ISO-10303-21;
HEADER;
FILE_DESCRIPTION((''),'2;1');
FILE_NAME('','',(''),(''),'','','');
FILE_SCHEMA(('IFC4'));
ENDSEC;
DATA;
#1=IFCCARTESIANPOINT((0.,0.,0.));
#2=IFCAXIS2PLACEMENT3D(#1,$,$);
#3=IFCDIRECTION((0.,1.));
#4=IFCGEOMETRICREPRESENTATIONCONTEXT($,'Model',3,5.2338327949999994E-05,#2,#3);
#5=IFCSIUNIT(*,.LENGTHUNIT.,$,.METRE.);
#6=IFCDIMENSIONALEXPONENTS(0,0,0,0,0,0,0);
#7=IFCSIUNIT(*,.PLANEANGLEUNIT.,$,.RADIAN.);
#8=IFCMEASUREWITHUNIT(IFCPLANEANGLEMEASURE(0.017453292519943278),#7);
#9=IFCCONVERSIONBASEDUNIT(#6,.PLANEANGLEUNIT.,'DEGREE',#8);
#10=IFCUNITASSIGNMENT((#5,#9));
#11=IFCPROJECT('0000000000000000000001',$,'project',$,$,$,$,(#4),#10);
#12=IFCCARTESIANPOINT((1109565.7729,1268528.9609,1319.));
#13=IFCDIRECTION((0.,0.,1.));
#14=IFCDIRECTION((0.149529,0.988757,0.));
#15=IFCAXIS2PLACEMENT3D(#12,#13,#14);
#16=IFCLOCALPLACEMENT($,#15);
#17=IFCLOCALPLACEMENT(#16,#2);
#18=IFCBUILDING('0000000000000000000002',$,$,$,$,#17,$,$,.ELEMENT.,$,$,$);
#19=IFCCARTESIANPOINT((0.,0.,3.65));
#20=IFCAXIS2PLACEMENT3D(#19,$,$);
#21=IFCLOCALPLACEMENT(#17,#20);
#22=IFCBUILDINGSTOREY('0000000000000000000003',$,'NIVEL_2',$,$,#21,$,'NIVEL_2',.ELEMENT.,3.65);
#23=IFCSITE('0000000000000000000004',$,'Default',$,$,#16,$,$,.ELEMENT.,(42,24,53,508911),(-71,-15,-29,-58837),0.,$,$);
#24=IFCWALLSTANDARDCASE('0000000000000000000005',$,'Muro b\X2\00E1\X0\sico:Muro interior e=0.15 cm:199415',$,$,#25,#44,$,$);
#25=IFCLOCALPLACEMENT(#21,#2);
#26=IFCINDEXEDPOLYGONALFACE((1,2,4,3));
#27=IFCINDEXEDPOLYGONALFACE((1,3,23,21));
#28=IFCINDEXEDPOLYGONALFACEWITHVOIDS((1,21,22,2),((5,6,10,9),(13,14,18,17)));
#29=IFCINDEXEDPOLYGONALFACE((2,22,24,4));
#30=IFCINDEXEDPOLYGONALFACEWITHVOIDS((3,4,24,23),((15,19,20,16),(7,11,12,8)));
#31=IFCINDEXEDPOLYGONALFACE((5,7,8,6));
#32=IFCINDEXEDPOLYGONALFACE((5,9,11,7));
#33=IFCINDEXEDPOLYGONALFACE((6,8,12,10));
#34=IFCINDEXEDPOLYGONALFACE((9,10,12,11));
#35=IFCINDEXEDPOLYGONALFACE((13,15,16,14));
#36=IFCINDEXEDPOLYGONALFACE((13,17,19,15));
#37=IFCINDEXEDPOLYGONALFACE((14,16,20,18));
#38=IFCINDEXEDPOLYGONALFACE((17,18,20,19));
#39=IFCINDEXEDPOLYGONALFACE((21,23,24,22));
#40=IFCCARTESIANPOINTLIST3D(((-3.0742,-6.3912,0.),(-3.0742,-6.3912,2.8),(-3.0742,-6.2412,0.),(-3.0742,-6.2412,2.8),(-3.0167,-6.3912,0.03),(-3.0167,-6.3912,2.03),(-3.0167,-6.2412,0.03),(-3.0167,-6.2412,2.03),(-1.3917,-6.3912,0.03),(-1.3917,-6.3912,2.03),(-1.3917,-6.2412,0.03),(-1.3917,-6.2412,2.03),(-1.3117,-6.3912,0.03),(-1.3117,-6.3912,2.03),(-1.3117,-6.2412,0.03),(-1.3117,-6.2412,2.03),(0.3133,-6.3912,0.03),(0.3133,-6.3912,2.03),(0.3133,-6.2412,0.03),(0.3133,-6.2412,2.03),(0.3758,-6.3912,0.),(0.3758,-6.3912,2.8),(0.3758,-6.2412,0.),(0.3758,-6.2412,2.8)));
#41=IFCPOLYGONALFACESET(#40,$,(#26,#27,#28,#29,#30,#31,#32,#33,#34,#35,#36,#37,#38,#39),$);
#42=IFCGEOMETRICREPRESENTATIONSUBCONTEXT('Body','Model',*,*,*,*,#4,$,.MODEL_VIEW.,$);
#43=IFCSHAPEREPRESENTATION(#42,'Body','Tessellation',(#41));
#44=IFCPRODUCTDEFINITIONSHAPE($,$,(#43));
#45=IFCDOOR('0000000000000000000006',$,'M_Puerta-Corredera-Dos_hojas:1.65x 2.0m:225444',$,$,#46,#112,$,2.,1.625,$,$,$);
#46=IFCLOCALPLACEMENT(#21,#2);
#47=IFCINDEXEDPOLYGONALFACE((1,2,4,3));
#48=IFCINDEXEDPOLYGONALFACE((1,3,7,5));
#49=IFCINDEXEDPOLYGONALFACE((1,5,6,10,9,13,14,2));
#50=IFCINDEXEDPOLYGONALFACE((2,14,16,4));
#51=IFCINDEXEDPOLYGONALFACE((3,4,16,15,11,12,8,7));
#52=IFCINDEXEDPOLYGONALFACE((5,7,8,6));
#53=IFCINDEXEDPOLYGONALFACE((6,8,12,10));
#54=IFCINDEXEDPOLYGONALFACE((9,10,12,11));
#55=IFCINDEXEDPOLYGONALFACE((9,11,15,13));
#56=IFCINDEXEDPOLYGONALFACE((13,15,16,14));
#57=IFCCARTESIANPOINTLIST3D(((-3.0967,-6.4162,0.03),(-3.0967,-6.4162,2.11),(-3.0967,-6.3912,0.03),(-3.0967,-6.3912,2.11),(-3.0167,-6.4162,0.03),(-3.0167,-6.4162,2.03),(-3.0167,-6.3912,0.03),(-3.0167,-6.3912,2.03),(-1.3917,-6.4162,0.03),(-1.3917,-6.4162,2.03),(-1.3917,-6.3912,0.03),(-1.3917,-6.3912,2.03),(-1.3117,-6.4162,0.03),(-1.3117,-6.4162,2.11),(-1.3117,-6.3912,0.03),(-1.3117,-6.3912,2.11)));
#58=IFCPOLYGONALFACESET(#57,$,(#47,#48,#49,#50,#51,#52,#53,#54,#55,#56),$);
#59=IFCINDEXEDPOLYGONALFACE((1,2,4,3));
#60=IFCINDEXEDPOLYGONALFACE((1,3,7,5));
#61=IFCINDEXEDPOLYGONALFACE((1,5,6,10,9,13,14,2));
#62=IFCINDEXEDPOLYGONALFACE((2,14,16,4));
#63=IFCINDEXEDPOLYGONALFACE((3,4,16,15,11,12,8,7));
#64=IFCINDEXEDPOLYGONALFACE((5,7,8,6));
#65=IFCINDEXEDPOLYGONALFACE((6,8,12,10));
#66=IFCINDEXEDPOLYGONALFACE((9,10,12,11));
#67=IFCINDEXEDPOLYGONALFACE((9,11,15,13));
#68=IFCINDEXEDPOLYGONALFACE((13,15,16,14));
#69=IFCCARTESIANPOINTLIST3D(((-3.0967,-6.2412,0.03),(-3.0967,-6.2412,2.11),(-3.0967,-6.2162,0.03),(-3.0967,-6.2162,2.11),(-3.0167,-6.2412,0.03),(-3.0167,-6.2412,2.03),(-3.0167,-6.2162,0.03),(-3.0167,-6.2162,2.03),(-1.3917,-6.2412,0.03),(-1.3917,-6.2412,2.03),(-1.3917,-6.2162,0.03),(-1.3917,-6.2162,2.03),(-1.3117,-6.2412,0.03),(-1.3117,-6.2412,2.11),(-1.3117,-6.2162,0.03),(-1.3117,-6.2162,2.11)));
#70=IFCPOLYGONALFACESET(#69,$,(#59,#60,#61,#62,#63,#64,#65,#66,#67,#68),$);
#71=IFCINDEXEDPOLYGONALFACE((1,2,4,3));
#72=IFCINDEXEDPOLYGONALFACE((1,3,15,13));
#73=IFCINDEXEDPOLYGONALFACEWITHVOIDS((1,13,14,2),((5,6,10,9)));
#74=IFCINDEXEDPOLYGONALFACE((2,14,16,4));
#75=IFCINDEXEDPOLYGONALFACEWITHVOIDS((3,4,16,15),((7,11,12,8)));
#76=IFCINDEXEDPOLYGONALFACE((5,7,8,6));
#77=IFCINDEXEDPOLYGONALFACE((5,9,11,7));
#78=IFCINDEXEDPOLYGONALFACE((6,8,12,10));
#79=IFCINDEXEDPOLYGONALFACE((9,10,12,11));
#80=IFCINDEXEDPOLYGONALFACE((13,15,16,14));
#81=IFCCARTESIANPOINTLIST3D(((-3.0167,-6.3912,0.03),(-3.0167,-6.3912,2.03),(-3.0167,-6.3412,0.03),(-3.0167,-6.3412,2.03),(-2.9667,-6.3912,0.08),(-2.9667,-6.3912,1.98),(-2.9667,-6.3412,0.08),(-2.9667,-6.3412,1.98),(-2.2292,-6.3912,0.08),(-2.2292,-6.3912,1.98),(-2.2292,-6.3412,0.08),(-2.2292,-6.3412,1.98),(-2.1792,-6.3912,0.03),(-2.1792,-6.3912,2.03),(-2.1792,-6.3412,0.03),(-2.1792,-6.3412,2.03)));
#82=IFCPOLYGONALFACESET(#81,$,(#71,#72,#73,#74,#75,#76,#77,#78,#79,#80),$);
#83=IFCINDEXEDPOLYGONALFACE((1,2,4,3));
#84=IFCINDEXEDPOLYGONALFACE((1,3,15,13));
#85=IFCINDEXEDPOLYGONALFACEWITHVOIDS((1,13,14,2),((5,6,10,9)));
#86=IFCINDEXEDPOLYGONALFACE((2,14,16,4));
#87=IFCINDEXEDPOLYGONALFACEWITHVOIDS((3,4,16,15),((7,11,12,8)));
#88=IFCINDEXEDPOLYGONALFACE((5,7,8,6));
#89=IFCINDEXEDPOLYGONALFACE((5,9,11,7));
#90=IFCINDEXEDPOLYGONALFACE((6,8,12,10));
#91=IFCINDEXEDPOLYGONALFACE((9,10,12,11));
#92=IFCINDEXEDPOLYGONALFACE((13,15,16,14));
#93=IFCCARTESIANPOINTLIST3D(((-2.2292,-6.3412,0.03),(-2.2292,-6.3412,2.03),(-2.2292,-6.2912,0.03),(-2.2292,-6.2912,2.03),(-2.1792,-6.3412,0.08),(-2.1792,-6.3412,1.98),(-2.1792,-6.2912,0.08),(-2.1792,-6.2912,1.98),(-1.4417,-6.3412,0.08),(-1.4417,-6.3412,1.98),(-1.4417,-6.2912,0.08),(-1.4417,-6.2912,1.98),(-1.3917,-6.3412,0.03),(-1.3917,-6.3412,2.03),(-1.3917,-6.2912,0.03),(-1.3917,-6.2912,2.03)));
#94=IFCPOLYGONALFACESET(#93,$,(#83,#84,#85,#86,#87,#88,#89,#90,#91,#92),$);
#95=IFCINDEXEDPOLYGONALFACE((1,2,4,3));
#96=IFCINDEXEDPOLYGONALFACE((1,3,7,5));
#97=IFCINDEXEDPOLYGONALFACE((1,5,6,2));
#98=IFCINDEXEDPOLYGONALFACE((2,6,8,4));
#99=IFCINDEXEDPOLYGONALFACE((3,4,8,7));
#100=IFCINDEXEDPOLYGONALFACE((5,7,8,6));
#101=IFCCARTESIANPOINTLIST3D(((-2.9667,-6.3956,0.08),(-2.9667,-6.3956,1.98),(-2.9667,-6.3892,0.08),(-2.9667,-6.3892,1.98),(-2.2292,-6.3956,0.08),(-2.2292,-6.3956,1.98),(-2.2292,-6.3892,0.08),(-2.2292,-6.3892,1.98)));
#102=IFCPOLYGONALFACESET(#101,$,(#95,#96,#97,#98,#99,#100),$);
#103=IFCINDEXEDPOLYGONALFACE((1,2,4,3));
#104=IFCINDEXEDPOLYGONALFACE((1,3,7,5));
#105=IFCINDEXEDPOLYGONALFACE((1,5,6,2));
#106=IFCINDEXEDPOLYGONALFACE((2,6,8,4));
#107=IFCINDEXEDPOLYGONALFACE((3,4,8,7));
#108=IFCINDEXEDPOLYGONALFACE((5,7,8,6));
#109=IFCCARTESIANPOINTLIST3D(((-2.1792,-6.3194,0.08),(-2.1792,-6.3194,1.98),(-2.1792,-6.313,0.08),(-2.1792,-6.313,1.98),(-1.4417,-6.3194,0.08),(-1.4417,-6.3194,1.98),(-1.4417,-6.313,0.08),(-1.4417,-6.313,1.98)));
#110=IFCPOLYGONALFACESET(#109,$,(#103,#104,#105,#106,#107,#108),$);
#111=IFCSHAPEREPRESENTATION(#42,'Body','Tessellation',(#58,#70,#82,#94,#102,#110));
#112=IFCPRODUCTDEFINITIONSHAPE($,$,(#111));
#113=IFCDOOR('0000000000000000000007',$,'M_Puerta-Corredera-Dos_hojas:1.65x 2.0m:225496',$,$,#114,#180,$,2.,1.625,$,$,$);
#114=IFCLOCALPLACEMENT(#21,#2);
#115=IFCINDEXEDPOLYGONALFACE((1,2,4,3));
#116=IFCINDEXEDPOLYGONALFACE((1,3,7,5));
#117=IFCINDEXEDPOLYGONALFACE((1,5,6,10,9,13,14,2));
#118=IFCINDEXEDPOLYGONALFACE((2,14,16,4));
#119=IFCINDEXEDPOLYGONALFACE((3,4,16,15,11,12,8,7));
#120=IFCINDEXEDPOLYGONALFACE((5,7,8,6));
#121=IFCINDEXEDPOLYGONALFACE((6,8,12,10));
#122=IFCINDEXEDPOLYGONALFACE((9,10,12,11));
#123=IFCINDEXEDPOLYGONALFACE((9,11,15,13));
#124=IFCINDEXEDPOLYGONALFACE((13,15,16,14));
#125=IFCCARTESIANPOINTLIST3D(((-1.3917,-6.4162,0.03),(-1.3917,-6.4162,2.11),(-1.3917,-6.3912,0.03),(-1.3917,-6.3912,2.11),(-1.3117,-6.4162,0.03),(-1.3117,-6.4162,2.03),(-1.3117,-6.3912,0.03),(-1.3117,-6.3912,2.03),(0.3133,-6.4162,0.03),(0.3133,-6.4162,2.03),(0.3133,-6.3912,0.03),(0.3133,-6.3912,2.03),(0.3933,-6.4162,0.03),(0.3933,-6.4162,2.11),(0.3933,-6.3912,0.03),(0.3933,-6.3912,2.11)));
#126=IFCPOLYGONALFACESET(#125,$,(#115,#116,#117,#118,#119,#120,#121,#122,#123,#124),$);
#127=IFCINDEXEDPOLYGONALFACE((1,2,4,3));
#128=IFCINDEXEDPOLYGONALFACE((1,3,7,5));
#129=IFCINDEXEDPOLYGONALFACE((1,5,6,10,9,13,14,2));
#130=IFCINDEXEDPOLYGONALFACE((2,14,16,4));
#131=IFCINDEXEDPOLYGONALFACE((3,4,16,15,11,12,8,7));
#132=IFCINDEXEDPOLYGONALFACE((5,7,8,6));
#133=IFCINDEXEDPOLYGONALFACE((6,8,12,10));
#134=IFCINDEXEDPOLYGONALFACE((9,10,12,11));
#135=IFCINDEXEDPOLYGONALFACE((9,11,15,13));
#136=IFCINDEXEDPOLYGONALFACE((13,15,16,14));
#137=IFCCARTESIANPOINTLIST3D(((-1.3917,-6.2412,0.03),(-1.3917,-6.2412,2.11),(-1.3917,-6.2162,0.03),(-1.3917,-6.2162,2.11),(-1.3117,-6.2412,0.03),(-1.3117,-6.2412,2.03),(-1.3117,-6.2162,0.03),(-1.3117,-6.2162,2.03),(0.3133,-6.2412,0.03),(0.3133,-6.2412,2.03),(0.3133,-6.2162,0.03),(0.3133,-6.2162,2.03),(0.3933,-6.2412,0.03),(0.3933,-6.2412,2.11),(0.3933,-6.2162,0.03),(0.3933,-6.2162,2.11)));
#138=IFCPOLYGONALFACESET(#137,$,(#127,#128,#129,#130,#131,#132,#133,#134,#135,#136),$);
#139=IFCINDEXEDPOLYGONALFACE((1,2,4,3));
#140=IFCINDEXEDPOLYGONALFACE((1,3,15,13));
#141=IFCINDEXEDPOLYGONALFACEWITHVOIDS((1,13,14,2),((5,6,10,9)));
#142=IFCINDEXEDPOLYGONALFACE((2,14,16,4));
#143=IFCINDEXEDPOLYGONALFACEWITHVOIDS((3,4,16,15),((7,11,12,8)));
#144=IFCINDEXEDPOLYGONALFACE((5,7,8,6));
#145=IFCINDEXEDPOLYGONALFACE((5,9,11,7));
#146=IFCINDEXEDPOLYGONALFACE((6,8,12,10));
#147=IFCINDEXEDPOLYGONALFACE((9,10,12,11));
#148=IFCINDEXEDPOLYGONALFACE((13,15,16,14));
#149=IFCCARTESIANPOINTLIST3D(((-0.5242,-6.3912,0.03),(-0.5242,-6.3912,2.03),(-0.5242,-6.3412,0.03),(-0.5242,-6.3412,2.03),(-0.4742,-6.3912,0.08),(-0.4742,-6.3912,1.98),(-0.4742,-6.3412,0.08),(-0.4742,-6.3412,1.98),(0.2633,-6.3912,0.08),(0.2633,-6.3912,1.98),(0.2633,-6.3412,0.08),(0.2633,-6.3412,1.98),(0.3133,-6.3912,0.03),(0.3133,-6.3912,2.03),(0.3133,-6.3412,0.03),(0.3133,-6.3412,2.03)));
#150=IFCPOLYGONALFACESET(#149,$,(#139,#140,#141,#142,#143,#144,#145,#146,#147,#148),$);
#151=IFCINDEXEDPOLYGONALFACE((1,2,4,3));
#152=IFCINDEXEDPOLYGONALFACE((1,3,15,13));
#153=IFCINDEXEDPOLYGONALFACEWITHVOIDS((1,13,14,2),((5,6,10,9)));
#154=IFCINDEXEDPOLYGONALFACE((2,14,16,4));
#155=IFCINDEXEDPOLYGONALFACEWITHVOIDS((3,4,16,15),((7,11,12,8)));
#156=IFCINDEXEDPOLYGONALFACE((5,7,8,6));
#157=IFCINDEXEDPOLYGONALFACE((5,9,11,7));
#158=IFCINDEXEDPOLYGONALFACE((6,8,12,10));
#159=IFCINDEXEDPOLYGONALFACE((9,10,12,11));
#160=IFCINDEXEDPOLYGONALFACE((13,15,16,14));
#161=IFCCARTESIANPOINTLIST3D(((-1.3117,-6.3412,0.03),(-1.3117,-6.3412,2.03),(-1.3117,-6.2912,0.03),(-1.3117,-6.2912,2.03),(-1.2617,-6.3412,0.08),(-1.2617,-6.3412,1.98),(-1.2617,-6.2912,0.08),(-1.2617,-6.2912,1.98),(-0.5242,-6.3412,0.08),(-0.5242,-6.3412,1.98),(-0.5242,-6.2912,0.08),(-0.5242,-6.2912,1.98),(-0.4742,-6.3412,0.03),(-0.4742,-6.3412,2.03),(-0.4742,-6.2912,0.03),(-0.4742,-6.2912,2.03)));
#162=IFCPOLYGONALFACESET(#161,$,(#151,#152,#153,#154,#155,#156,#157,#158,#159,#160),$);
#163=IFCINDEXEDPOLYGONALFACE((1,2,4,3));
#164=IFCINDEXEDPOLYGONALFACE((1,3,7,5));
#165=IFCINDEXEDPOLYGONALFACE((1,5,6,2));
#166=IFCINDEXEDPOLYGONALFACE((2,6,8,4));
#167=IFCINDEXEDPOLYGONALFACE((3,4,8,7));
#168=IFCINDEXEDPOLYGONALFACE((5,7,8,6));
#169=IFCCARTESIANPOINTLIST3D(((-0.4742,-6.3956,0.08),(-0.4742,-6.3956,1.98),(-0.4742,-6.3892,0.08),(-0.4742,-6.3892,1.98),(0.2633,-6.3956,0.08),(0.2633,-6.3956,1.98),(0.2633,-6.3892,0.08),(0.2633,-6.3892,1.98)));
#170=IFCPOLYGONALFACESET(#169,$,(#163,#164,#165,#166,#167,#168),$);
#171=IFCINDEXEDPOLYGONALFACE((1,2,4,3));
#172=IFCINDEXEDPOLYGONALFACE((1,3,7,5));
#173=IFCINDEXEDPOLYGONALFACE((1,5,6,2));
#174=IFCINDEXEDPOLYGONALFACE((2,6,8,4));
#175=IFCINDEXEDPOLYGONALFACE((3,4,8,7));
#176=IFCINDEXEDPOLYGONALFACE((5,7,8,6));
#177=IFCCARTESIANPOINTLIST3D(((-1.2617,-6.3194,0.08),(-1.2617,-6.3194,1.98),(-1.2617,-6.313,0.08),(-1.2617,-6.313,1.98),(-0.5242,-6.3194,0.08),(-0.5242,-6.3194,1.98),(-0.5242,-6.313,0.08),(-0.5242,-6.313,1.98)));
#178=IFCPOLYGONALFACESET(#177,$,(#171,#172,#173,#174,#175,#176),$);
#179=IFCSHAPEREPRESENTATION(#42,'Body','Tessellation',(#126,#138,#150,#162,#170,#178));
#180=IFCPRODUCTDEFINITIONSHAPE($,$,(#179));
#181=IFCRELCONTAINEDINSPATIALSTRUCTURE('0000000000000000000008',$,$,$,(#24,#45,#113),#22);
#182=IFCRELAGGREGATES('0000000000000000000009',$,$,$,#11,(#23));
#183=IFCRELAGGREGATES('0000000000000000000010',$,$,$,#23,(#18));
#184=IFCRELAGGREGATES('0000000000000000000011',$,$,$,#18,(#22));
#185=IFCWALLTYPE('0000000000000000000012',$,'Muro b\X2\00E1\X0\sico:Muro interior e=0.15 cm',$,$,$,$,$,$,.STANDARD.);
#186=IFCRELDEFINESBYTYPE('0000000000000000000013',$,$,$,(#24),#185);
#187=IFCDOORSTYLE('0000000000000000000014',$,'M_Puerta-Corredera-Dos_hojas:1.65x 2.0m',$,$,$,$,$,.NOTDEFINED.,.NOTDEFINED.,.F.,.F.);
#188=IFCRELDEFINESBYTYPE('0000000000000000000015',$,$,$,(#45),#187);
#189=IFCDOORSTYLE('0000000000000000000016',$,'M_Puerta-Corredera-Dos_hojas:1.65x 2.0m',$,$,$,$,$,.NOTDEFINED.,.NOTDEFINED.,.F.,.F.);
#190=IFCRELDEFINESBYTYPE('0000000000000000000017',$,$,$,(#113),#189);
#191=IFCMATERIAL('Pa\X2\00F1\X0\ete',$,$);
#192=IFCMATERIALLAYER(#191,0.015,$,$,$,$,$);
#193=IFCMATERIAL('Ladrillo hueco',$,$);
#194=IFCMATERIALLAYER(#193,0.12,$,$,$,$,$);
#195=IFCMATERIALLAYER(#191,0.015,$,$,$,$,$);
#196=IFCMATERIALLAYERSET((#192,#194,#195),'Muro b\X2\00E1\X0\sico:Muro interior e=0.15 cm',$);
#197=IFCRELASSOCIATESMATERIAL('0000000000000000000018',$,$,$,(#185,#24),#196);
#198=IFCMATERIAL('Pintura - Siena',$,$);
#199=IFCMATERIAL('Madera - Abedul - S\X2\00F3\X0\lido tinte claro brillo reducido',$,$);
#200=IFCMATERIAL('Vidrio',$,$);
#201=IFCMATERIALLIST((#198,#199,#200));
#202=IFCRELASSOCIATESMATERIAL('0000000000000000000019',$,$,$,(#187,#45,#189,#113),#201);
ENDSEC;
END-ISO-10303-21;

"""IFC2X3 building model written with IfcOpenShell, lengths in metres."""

from ifc_helpers import new_model, entity, si_unit, converted_unit, direction, frame, frame_2d, origin, origin_2d_with_axis, place, context, subcontext, project, spatial, polyline, rectangle, outline, extrude, source, transform, mapped, material, material_list, layer, layer_set, layer_usage, type_object, type_shapes, element, fill, save


model = new_model("IFC2X3")

# Units and contexts
model_context = context("Model", 3, precision=5.2338327949999994e-05, world=origin(), true_north=direction((0.0, 1.0)))
body_context = subcontext(model_context, "Body", "Model", "MODEL_VIEW")
ifc_project = project(units=[si_unit("LENGTHUNIT", "METRE"), converted_unit("PLANEANGLEUNIT", "DEGREE", entity("IfcPlaneAngleMeasure", 0.017453292519943278), si_unit("PLANEANGLEUNIT", "RADIAN"), dimensions=[0, 0, 0, 0, 0, 0, 0])], contexts=[model_context])

# Site, building, storey
site_placement = place(None, frame((1109565.7729, 1268528.9609, 1319.0), z_axis=(0.0, 0.0, 1.0), x_axis=(0.149529, 0.988757, 0.0)))
site = spatial("IfcSite", under=ifc_project, at=site_placement, Name="Default", CompositionType="ELEMENT", RefLatitude=(42, 24, 53, 508911), RefLongitude=(-71, -15, -29, -58837), RefElevation=0.0)
building_placement = place(site_placement, origin())
building = spatial("IfcBuilding", under=site, at=building_placement, CompositionType="ELEMENT")
storey_placement = place(building_placement, frame((0.0, 0.0, 3.65)))
storey = spatial("IfcBuildingStorey", under=building, at=storey_placement, Name="NIVEL_2", LongName="NIVEL_2", CompositionType="ELEMENT", Elevation=3.65)

# Shared definitions
ifc_material_1 = material(Name="Pañete")
ifc_layer_1 = layer(ifc_material_1, 0.015)
ifc_material_2 = material(Name="Ladrillo hueco")
ifc_layer_2 = layer(ifc_material_2, 0.12)
ifc_layer_3 = layer(ifc_material_1, 0.015)
ifc_layer_set_1 = layer_set([ifc_layer_1, ifc_layer_2, ifc_layer_3], Name="Muro básico:Muro interior e=0.15 cm")
wall_type_1 = type_object("IfcWallType", Name="Muro básico:Muro interior e=0.15 cm", PredefinedType="STANDARD", material=ifc_layer_set_1)

# Wall, openings, doors
ifc_layer_usage_1 = layer_usage(ifc_layer_set_1, "AXIS2", "NEGATIVE", 0.075)
wall_1_placement = place(storey_placement, frame((-3.0742, -6.3162, 0.0)))
wall_1 = element("IfcWallStandardCase", 1, at=wall_1_placement, inside=storey, type_object=wall_type_1, material=ifc_layer_usage_1, Name="Muro básico:Muro interior e=0.15 cm:199415", context=body_context, shape_type="SweptSolid", body=[
    extrude(rectangle(XDim=3.45, YDim=0.15, at=frame_2d((1.725, 0.0), x_axis=(-1.0, 0.0))), origin(), (0.0, 0.0, 1.0), 2.8),
])
opening_1_placement = place(wall_1_placement, frame((1.6825, 0.075, 0.03)))
opening_1 = element("IfcOpeningElement", 2, at=opening_1_placement, cuts=wall_1, ObjectType="Opening", context=body_context, shape_type="SweptSolid", body=[
    extrude(rectangle(XDim=2.0, YDim=1.625, at=frame_2d((1.0, 0.8125), x_axis=(-1.0, 0.0))), frame((0.0, 0.0, 0.0), z_axis=(0.0, -1.0, 0.0), x_axis=(0.0, 0.0, 1.0)), (0.0, 0.0, 1.0), 0.15),
])
opening_2_placement = place(wall_1_placement, frame((3.3875, 0.075, 0.03)))
opening_2 = element("IfcOpeningElement", 3, at=opening_2_placement, cuts=wall_1, ObjectType="Opening", context=body_context, shape_type="SweptSolid", body=[
    extrude(rectangle(XDim=2.0, YDim=1.625, at=frame_2d((1.0, 0.8125), x_axis=(-1.0, 0.0))), frame((0.0, 0.0, 0.0), z_axis=(0.0, -1.0, 0.0), x_axis=(0.0, 0.0, 1.0)), (0.0, 0.0, 1.0), 0.15),
])
ifc_material_3 = material(Name="Pintura - Siena")
ifc_material_4 = material(Name="Madera - Abedul - Sólido tinte claro brillo reducido")
ifc_material_5 = material(Name="Vidrio")
ifc_material_list_1 = material_list([ifc_material_3, ifc_material_4, ifc_material_5])
door_style_1 = type_object("IfcDoorStyle", Name="M_Puerta-Corredera-Dos_hojas:1.65x 2.0m", ConstructionType="NOTDEFINED", OperationType="NOTDEFINED", ParameterTakesPrecedence=False, Sizeable=False, material=ifc_material_list_1)
shared_shape_1 = source(origin(), body_context, "Body", "SweptSolid", [
    extrude(outline(polyline([(-0.8925, -1.02), (-0.8125, -1.02), (-0.8125, 0.98), (0.8125, 0.98), (0.8125, -1.02), (0.8925, -1.02), (0.8925, 1.06), (-0.8925, 1.06), (-0.8925, -1.02)])), frame((0.8125, 0.429, 1.02), z_axis=(0.0, -1.0, 0.0), x_axis=(1.0, 0.0, 0.0)), (0.0, 0.0, 1.0), 0.025),
    extrude(outline(polyline([(-1.02, -0.8925), (1.06, -0.8925), (1.06, 0.8925), (-1.02, 0.8925), (-1.02, 0.8125), (0.98, 0.8125), (0.98, -0.8125), (-1.02, -0.8125), (-1.02, -0.8925)])), frame((0.8125, 0.254, 1.02), z_axis=(0.0, -1.0, 0.0), x_axis=(0.0, 0.0, 1.0)), (0.0, 0.0, 1.0), 0.025),
    extrude(outline(polyline([(-1.0, -0.4187), (1.0, -0.4187), (1.0, 0.4187), (-1.0, 0.4187), (-1.0, -0.4187)]), holes=[polyline([(-0.95, -0.3688), (-0.95, 0.3687), (0.95, 0.3687), (0.95, -0.3688), (-0.95, -0.3688)])]), frame((1.2063, 0.404, 1.0), z_axis=(0.0, -1.0, 0.0), x_axis=(0.0, 0.0, -1.0)), (0.0, 0.0, 1.0), 0.05),
    extrude(outline(polyline([(-0.4187, -1.0), (0.4187, -1.0), (0.4187, 1.0), (-0.4187, 1.0), (-0.4187, -1.0)]), holes=[polyline([(-0.3688, -0.95), (-0.3688, 0.95), (0.3688, 0.95), (0.3688, -0.95), (-0.3688, -0.95)])]), frame((0.4187, 0.354, 1.0), z_axis=(0.0, -1.0, 0.0), x_axis=(-1.0, 0.0, 0.0)), (0.0, 0.0, 1.0), 0.05),
    extrude(rectangle(XDim=0.7375, YDim=0.0064, at=origin_2d_with_axis()), frame((1.2062, 0.4052, 0.05)), (0.0, 0.0, 1.0), 1.9),
    extrude(rectangle(XDim=0.7375, YDim=0.0063, at=frame_2d((0.0, 0.0), x_axis=(1.0, 0.0))), frame((0.4187, 0.329, 0.05), z_axis=(0.0, 0.0, 1.0), x_axis=(-1.0, 0.0, 0.0)), (0.0, 0.0, 1.0), 1.9),
])
type_shapes(door_style_1, [shared_shape_1])
door_1_placement = place(opening_1_placement, frame((0.0, 0.254, 0.0), z_axis=(0.0, 0.0, 1.0), x_axis=(-1.0, 0.0, 0.0)))
door_1 = element("IfcDoor", 4, at=door_1_placement, inside=storey, type_object=door_style_1, material=ifc_material_list_1, Name="M_Puerta-Corredera-Dos_hojas:1.65x 2.0m:225444", OverallHeight=2.0, OverallWidth=1.625, context=body_context, shape_type="MappedRepresentation", body=[
    mapped(shared_shape_1, transform((0.0, 0.0, 0.0), scale=1.0)),
])
fill(opening_1, door_1)
door_style_2 = type_object("IfcDoorStyle", Name="M_Puerta-Corredera-Dos_hojas:1.65x 2.0m", ConstructionType="NOTDEFINED", OperationType="NOTDEFINED", ParameterTakesPrecedence=False, Sizeable=False, material=ifc_material_list_1)
shared_shape_2 = source(origin(), body_context, "Body", "SweptSolid", [
    extrude(outline(polyline([(-0.8925, -1.02), (-0.8125, -1.02), (-0.8125, 0.98), (0.8125, 0.98), (0.8125, -1.02), (0.8925, -1.02), (0.8925, 1.06), (-0.8925, 1.06), (-0.8925, -1.02)])), frame((0.8125, 0.15, 1.02), z_axis=(0.0, 1.0, 0.0), x_axis=(-1.0, 0.0, 0.0)), (0.0, 0.0, 1.0), 0.025),
    extrude(outline(polyline([(-1.02, -0.8925), (1.06, -0.8925), (1.06, 0.8925), (-1.02, 0.8925), (-1.02, 0.8125), (0.98, 0.8125), (0.98, -0.8125), (-1.02, -0.8125), (-1.02, -0.8925)])), frame((0.8125, -0.025, 1.02), z_axis=(0.0, 1.0, 0.0), x_axis=(0.0, 0.0, 1.0)), (0.0, 0.0, 1.0), 0.025),
    extrude(outline(polyline([(-1.0, -0.4187), (1.0, -0.4187), (1.0, 0.4187), (-1.0, 0.4187), (-1.0, -0.4187)]), holes=[polyline([(-0.95, -0.3688), (-0.95, 0.3687), (0.95, 0.3687), (0.95, -0.3688), (-0.95, -0.3688)])]), frame((0.4188, 0.1, 1.0), z_axis=(0.0, 1.0, 0.0), x_axis=(0.0, 0.0, -1.0)), (0.0, 0.0, 1.0), 0.05),
    extrude(outline(polyline([(-0.4187, -1.0), (0.4187, -1.0), (0.4187, 1.0), (-0.4187, 1.0), (-0.4187, -1.0)]), holes=[polyline([(-0.3688, -0.95), (-0.3688, 0.95), (0.3688, 0.95), (0.3688, -0.95), (-0.3688, -0.95)])]), frame((1.2063, 0.05, 1.0), z_axis=(0.0, 1.0, 0.0), x_axis=(1.0, 0.0, 0.0)), (0.0, 0.0, 1.0), 0.05),
    extrude(rectangle(XDim=0.0064, YDim=0.7375, at=origin_2d_with_axis()), frame((0.4188, 0.1512, 0.05), z_axis=(0.0, 0.0, 1.0), x_axis=(0.0, 1.0, 0.0)), (0.0, 0.0, 1.0), 1.9),
    extrude(rectangle(XDim=0.0063, YDim=0.7375, at=frame_2d((0.0, 0.0), x_axis=(1.0, 0.0))), frame((1.2063, 0.075, 0.05), z_axis=(0.0, 0.0, 1.0), x_axis=(0.0, -1.0, 0.0)), (0.0, 0.0, 1.0), 1.9),
])
type_shapes(door_style_2, [shared_shape_2])
door_2_placement = place(opening_2_placement, frame((0.0, 0.0, 0.0), z_axis=(0.0, 0.0, 1.0), x_axis=(-1.0, 0.0, 0.0)))
door_2 = element("IfcDoor", 5, at=door_2_placement, inside=storey, type_object=door_style_2, material=ifc_material_list_1, Name="M_Puerta-Corredera-Dos_hojas:1.65x 2.0m:225496", OverallHeight=2.0, OverallWidth=1.625, context=body_context, shape_type="MappedRepresentation", body=[
    mapped(shared_shape_2, transform((0.0, 0.0, 0.0), scale=1.0)),
])
fill(opening_2, door_2)

save(model, "model.ifc")
